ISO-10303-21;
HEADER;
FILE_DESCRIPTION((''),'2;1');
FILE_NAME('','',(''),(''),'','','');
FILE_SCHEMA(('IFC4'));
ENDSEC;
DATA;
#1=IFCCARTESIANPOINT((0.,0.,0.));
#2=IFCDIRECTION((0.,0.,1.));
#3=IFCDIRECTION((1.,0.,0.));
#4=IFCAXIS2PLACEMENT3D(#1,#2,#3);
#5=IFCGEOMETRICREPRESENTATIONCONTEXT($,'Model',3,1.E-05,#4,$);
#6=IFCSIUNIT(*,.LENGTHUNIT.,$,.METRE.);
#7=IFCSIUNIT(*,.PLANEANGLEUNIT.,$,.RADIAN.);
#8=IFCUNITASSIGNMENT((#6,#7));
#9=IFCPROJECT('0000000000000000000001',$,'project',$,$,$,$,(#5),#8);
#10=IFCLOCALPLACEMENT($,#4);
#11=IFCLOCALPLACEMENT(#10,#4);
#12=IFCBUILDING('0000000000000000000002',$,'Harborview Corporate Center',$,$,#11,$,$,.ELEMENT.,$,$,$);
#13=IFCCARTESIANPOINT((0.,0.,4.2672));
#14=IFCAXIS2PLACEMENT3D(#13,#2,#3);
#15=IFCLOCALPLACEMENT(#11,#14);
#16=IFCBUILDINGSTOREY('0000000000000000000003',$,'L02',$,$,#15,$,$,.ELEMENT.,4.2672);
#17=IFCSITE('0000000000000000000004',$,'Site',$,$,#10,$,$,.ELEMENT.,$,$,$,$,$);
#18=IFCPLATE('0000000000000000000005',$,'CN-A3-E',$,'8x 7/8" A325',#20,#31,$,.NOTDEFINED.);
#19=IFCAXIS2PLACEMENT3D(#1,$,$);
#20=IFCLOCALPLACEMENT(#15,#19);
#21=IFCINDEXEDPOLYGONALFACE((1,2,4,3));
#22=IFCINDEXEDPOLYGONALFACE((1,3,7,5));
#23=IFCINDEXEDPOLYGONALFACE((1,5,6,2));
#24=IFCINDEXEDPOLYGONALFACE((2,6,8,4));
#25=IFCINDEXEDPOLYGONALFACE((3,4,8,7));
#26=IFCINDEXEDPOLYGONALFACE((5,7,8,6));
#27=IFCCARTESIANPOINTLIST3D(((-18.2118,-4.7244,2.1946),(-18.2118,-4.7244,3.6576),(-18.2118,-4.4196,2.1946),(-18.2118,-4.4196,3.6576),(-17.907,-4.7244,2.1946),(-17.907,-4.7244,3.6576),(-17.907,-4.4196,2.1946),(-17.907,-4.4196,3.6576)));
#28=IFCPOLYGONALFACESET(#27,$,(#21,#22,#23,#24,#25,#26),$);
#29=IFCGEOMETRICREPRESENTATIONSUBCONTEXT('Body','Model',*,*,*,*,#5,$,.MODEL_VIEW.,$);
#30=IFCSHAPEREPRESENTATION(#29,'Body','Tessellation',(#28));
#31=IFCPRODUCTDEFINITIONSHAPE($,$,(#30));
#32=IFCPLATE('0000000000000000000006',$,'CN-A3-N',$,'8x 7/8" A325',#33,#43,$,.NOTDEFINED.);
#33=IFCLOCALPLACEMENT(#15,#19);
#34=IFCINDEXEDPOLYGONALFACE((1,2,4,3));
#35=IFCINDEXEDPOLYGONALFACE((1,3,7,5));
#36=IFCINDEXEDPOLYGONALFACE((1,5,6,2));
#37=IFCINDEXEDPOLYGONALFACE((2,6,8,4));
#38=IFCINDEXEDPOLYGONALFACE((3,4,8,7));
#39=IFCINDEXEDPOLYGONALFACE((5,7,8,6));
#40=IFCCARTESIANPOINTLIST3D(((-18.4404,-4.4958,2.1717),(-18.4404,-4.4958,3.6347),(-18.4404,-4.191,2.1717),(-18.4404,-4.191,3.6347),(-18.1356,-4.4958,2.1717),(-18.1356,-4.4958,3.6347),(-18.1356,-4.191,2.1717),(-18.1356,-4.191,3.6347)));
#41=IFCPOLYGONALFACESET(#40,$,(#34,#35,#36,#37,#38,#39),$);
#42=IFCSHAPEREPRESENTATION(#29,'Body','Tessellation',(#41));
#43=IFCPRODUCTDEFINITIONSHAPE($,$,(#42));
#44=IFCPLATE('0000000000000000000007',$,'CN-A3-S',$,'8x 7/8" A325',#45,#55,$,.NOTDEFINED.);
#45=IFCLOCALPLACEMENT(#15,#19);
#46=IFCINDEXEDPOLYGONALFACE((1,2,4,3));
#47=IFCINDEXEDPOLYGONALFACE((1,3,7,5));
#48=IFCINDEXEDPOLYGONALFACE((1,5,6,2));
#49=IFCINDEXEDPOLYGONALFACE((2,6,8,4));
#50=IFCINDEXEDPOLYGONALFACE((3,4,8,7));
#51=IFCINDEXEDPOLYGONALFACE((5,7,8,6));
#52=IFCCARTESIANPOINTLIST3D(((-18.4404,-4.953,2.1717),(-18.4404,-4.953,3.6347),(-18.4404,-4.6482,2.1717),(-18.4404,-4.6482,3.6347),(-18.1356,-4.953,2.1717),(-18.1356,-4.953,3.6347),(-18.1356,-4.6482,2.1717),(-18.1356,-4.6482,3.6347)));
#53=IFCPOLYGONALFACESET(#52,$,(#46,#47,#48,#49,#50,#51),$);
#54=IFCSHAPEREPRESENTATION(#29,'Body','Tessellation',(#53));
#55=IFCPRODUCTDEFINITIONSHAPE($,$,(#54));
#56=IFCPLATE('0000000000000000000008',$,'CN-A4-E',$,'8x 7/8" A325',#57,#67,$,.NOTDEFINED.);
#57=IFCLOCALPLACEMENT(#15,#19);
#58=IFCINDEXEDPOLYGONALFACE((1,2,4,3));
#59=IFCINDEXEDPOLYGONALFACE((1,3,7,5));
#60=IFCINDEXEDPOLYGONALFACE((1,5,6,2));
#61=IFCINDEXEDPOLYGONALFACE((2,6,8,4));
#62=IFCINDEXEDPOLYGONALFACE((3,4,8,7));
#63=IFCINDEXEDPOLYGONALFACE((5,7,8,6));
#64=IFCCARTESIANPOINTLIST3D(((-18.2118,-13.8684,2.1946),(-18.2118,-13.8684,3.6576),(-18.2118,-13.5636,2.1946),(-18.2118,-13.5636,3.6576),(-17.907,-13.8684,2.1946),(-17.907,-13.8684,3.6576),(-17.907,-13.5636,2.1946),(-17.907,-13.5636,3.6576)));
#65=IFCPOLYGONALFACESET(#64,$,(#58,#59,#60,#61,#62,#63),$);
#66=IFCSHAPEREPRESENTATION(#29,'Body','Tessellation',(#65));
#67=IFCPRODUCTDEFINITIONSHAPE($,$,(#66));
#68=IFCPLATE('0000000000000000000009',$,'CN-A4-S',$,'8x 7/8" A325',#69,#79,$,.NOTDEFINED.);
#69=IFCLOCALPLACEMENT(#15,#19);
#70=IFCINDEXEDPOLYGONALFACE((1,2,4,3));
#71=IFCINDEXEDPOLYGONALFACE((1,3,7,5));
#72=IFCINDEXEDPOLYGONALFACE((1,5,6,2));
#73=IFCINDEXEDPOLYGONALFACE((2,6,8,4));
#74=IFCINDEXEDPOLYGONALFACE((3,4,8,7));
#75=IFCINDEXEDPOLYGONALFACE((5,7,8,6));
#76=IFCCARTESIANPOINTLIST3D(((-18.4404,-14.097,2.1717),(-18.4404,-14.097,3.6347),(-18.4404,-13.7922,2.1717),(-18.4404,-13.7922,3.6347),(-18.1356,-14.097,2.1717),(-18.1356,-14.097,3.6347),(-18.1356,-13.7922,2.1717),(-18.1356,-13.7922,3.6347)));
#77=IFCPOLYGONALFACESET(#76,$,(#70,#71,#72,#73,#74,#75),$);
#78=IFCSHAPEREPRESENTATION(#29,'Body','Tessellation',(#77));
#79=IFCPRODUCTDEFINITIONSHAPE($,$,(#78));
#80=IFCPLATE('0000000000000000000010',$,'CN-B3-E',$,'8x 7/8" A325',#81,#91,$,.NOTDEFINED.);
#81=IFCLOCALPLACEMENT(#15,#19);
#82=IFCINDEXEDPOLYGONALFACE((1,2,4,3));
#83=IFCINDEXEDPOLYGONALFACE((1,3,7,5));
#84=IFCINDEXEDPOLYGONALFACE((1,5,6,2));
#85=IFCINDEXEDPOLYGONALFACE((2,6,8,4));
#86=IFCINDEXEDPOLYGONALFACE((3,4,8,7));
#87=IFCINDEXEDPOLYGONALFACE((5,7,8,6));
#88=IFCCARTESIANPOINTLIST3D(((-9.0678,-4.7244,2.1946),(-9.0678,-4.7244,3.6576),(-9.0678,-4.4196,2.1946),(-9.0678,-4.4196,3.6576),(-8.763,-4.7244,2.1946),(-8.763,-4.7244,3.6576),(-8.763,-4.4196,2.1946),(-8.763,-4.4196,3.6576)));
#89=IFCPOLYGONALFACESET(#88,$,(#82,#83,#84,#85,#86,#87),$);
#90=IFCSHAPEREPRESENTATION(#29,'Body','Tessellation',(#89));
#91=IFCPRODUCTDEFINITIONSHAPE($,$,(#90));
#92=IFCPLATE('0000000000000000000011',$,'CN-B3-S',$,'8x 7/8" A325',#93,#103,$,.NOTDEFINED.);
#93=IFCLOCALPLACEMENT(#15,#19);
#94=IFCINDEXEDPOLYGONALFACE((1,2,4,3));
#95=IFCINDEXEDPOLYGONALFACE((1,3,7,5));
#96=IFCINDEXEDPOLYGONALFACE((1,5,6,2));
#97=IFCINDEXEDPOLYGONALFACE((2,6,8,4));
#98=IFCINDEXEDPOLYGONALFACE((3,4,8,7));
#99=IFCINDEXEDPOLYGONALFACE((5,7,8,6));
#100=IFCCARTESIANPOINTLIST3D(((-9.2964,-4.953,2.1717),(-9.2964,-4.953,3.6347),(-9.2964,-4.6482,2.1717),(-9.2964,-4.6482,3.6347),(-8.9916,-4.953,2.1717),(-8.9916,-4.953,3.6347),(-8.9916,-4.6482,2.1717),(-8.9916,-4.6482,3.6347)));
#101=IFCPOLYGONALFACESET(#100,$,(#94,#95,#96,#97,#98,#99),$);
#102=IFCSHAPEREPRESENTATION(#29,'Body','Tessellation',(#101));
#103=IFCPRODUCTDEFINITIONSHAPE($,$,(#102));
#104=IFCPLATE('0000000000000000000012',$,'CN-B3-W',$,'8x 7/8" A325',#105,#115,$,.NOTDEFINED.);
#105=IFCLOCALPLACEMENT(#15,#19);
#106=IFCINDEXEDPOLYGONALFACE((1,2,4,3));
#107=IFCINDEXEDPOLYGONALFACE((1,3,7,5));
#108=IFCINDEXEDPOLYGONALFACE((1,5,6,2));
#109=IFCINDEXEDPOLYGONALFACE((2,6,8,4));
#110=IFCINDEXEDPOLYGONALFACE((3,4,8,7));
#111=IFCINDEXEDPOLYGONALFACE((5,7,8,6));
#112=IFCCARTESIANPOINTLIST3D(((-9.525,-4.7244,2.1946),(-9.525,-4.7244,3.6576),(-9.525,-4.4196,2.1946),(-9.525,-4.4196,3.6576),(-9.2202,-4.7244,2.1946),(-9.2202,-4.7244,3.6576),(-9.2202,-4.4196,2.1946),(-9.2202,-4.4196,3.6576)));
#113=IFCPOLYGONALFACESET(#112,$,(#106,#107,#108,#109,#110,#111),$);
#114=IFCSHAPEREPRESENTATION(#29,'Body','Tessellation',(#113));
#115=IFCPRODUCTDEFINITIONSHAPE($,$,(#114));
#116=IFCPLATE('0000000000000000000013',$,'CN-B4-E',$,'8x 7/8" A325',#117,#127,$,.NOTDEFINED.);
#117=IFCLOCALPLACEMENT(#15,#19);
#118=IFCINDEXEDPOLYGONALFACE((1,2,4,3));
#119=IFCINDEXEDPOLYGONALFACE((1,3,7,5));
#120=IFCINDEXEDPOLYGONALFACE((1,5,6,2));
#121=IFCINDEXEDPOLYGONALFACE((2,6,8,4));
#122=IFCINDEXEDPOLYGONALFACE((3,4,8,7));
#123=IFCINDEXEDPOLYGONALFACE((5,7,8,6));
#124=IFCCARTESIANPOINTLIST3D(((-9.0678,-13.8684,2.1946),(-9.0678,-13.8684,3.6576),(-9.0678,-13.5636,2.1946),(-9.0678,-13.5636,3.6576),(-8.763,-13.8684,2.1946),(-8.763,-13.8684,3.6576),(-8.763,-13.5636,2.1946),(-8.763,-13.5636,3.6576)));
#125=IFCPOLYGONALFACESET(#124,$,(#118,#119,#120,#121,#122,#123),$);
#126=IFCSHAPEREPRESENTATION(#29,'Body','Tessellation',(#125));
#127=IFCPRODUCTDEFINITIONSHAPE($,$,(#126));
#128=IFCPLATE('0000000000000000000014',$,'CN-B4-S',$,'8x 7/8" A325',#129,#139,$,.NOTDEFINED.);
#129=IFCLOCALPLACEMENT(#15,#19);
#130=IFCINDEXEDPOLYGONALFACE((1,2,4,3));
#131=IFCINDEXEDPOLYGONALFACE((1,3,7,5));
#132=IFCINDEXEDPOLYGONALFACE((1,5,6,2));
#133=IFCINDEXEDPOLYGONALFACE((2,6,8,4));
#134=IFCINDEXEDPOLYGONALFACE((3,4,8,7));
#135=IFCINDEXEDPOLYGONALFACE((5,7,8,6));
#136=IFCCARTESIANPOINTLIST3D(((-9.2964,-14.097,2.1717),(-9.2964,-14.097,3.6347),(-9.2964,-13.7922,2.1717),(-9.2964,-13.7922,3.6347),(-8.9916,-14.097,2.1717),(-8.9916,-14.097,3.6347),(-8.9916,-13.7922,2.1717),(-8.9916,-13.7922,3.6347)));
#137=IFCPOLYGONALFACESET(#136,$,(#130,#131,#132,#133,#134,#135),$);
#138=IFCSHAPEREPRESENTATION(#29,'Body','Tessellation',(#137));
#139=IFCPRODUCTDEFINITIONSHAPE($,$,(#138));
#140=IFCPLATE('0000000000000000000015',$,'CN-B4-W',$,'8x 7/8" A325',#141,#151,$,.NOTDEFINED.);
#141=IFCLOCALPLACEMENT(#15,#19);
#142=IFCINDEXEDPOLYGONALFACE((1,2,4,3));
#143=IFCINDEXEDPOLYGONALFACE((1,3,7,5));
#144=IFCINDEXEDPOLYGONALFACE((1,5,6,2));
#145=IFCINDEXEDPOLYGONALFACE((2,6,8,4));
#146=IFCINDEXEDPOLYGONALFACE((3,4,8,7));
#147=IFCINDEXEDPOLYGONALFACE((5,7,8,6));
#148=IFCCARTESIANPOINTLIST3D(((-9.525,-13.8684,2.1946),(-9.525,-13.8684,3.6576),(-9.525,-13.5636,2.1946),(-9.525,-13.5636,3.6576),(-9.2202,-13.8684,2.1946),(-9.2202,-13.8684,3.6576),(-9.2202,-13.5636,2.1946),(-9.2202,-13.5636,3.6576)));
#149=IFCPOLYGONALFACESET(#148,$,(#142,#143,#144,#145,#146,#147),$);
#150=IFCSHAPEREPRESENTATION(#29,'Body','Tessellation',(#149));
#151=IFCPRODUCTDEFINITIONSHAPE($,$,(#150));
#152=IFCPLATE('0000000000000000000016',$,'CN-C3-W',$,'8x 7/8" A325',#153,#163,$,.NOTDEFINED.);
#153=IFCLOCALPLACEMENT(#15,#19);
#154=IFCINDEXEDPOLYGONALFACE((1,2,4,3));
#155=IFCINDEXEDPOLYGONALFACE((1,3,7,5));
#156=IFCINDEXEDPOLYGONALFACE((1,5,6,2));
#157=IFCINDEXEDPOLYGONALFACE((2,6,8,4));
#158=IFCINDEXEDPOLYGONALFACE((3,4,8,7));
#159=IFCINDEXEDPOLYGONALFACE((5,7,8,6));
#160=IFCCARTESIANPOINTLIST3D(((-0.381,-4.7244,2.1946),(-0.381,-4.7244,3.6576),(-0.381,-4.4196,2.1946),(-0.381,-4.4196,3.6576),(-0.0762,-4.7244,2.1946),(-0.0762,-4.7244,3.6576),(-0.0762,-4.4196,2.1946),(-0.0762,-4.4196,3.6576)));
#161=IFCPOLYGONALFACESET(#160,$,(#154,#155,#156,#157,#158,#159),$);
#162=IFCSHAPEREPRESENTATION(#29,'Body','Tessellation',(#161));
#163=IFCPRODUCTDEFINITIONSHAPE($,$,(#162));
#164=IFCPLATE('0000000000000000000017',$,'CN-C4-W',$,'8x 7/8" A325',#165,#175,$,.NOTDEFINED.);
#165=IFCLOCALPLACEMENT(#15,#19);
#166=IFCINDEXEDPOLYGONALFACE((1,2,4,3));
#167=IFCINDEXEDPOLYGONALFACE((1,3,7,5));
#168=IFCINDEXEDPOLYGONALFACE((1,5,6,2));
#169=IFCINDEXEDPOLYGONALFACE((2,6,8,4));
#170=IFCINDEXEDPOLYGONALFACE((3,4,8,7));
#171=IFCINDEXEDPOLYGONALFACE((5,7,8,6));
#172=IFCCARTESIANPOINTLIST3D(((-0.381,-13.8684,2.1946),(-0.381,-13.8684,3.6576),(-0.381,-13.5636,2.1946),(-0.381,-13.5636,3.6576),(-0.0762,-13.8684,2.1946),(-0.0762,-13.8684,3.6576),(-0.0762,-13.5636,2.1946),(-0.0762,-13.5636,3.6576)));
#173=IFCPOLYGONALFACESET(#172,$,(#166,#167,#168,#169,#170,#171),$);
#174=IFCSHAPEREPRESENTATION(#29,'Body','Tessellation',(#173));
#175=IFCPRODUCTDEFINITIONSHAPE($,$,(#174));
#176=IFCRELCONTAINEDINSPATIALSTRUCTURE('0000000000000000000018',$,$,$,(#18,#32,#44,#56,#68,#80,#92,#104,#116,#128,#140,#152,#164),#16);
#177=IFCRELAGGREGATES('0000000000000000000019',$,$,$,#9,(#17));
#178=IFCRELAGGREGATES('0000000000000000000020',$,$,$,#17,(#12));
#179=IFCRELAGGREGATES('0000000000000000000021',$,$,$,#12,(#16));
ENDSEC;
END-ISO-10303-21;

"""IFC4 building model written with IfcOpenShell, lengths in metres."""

from ifc_helpers import new_model, si_unit, frame, origin_with_axes, place, context, subcontext, project, spatial, rectangle, extrude, element, save


model = new_model("IFC4")

# Units and contexts
model_context = context("Model", 3, precision=1e-05, world=origin_with_axes())
body_context = subcontext(model_context, "Body", "Model", "MODEL_VIEW")
ifc_project = project(units=[si_unit("LENGTHUNIT", "METRE"), si_unit("PLANEANGLEUNIT", "RADIAN")], contexts=[model_context])

# Site, building, storey
site_placement = place(None, origin_with_axes())
site = spatial("IfcSite", under=ifc_project, at=site_placement, Name="Site", CompositionType="ELEMENT")
building_placement = place(site_placement, origin_with_axes())
building = spatial("IfcBuilding", under=site, at=building_placement, Name="Harborview Corporate Center", CompositionType="ELEMENT")
storey_placement = place(building_placement, frame((0.0, 0.0, 4.2672), z_axis=(0.0, 0.0, 1.0), x_axis=(1.0, 0.0, 0.0)))
storey = spatial("IfcBuildingStorey", under=building, at=storey_placement, Name="L02", CompositionType="ELEMENT", Elevation=4.2672)

# Plates
for number, where, z_axis, x_axis, name in (
    (1, (-18.0594, -4.572, 2.1946), (0.0, 0.0, 1.0), (1.0, 0.0, 0.0), "CN-A3-E"),
    (2, (-18.288, -4.3434, 2.1717), (0.0, 0.0, 1.0), (1.0, 0.0, 0.0), "CN-A3-N"),
    (3, (-18.288, -4.8006, 2.1717), (0.0, 0.0, 1.0), (1.0, 0.0, 0.0), "CN-A3-S"),
    (4, (-18.0594, -13.716, 2.1946), (0.0, 0.0, 1.0), (1.0, 0.0, 0.0), "CN-A4-E"),
    (5, (-18.288, -13.9446, 2.1717), (0.0, 0.0, 1.0), (1.0, 0.0, 0.0), "CN-A4-S"),
    (6, (-8.9154, -4.572, 2.1946), (0.0, 0.0, 1.0), (1.0, 0.0, 0.0), "CN-B3-E"),
    (7, (-9.144, -4.8006, 2.1717), (0.0, 0.0, 1.0), (1.0, 0.0, 0.0), "CN-B3-S"),
    (8, (-9.3726, -4.572, 2.1946), (0.0, 0.0, 1.0), (1.0, 0.0, 0.0), "CN-B3-W"),
    (9, (-8.9154, -13.716, 2.1946), (0.0, 0.0, 1.0), (1.0, 0.0, 0.0), "CN-B4-E"),
    (10, (-9.144, -13.9446, 2.1717), (0.0, 0.0, 1.0), (1.0, 0.0, 0.0), "CN-B4-S"),
    (11, (-9.3726, -13.716, 2.1946), (0.0, 0.0, 1.0), (1.0, 0.0, 0.0), "CN-B4-W"),
):
    element("IfcPlate", number, at=place(storey_placement, frame(where, z_axis=z_axis, x_axis=x_axis)), inside=storey, Name=name, ObjectType="8x 7/8\" A325", PredefinedType="NOTDEFINED", context=body_context, shape_type="SweptSolid", body=[
        extrude(rectangle(XDim=0.3048, YDim=0.3048), origin_with_axes(), (0.0, 0.0, 1.0), 1.463),
    ])
for number, where, z_axis, x_axis, name in (
    (12, (-0.2286, -4.572, 2.1946), (0.0, 0.0, 1.0), (1.0, 0.0, 0.0), "CN-C3-W"),
    (13, (-0.2286, -13.716, 2.1946), (0.0, 0.0, 1.0), (1.0, 0.0, 0.0), "CN-C4-W"),
):
    element("IfcPlate", number, at=place(storey_placement, frame(where, z_axis=z_axis, x_axis=x_axis)), inside=storey, Name=name, ObjectType="8x 7/8\" A325", PredefinedType="NOTDEFINED", context=body_context, shape_type="SweptSolid", body=[
        extrude(rectangle(XDim=0.3048, YDim=0.3048), origin_with_axes(), (0.0, 0.0, 1.0), 1.463),
    ])

save(model, "model.ifc")
